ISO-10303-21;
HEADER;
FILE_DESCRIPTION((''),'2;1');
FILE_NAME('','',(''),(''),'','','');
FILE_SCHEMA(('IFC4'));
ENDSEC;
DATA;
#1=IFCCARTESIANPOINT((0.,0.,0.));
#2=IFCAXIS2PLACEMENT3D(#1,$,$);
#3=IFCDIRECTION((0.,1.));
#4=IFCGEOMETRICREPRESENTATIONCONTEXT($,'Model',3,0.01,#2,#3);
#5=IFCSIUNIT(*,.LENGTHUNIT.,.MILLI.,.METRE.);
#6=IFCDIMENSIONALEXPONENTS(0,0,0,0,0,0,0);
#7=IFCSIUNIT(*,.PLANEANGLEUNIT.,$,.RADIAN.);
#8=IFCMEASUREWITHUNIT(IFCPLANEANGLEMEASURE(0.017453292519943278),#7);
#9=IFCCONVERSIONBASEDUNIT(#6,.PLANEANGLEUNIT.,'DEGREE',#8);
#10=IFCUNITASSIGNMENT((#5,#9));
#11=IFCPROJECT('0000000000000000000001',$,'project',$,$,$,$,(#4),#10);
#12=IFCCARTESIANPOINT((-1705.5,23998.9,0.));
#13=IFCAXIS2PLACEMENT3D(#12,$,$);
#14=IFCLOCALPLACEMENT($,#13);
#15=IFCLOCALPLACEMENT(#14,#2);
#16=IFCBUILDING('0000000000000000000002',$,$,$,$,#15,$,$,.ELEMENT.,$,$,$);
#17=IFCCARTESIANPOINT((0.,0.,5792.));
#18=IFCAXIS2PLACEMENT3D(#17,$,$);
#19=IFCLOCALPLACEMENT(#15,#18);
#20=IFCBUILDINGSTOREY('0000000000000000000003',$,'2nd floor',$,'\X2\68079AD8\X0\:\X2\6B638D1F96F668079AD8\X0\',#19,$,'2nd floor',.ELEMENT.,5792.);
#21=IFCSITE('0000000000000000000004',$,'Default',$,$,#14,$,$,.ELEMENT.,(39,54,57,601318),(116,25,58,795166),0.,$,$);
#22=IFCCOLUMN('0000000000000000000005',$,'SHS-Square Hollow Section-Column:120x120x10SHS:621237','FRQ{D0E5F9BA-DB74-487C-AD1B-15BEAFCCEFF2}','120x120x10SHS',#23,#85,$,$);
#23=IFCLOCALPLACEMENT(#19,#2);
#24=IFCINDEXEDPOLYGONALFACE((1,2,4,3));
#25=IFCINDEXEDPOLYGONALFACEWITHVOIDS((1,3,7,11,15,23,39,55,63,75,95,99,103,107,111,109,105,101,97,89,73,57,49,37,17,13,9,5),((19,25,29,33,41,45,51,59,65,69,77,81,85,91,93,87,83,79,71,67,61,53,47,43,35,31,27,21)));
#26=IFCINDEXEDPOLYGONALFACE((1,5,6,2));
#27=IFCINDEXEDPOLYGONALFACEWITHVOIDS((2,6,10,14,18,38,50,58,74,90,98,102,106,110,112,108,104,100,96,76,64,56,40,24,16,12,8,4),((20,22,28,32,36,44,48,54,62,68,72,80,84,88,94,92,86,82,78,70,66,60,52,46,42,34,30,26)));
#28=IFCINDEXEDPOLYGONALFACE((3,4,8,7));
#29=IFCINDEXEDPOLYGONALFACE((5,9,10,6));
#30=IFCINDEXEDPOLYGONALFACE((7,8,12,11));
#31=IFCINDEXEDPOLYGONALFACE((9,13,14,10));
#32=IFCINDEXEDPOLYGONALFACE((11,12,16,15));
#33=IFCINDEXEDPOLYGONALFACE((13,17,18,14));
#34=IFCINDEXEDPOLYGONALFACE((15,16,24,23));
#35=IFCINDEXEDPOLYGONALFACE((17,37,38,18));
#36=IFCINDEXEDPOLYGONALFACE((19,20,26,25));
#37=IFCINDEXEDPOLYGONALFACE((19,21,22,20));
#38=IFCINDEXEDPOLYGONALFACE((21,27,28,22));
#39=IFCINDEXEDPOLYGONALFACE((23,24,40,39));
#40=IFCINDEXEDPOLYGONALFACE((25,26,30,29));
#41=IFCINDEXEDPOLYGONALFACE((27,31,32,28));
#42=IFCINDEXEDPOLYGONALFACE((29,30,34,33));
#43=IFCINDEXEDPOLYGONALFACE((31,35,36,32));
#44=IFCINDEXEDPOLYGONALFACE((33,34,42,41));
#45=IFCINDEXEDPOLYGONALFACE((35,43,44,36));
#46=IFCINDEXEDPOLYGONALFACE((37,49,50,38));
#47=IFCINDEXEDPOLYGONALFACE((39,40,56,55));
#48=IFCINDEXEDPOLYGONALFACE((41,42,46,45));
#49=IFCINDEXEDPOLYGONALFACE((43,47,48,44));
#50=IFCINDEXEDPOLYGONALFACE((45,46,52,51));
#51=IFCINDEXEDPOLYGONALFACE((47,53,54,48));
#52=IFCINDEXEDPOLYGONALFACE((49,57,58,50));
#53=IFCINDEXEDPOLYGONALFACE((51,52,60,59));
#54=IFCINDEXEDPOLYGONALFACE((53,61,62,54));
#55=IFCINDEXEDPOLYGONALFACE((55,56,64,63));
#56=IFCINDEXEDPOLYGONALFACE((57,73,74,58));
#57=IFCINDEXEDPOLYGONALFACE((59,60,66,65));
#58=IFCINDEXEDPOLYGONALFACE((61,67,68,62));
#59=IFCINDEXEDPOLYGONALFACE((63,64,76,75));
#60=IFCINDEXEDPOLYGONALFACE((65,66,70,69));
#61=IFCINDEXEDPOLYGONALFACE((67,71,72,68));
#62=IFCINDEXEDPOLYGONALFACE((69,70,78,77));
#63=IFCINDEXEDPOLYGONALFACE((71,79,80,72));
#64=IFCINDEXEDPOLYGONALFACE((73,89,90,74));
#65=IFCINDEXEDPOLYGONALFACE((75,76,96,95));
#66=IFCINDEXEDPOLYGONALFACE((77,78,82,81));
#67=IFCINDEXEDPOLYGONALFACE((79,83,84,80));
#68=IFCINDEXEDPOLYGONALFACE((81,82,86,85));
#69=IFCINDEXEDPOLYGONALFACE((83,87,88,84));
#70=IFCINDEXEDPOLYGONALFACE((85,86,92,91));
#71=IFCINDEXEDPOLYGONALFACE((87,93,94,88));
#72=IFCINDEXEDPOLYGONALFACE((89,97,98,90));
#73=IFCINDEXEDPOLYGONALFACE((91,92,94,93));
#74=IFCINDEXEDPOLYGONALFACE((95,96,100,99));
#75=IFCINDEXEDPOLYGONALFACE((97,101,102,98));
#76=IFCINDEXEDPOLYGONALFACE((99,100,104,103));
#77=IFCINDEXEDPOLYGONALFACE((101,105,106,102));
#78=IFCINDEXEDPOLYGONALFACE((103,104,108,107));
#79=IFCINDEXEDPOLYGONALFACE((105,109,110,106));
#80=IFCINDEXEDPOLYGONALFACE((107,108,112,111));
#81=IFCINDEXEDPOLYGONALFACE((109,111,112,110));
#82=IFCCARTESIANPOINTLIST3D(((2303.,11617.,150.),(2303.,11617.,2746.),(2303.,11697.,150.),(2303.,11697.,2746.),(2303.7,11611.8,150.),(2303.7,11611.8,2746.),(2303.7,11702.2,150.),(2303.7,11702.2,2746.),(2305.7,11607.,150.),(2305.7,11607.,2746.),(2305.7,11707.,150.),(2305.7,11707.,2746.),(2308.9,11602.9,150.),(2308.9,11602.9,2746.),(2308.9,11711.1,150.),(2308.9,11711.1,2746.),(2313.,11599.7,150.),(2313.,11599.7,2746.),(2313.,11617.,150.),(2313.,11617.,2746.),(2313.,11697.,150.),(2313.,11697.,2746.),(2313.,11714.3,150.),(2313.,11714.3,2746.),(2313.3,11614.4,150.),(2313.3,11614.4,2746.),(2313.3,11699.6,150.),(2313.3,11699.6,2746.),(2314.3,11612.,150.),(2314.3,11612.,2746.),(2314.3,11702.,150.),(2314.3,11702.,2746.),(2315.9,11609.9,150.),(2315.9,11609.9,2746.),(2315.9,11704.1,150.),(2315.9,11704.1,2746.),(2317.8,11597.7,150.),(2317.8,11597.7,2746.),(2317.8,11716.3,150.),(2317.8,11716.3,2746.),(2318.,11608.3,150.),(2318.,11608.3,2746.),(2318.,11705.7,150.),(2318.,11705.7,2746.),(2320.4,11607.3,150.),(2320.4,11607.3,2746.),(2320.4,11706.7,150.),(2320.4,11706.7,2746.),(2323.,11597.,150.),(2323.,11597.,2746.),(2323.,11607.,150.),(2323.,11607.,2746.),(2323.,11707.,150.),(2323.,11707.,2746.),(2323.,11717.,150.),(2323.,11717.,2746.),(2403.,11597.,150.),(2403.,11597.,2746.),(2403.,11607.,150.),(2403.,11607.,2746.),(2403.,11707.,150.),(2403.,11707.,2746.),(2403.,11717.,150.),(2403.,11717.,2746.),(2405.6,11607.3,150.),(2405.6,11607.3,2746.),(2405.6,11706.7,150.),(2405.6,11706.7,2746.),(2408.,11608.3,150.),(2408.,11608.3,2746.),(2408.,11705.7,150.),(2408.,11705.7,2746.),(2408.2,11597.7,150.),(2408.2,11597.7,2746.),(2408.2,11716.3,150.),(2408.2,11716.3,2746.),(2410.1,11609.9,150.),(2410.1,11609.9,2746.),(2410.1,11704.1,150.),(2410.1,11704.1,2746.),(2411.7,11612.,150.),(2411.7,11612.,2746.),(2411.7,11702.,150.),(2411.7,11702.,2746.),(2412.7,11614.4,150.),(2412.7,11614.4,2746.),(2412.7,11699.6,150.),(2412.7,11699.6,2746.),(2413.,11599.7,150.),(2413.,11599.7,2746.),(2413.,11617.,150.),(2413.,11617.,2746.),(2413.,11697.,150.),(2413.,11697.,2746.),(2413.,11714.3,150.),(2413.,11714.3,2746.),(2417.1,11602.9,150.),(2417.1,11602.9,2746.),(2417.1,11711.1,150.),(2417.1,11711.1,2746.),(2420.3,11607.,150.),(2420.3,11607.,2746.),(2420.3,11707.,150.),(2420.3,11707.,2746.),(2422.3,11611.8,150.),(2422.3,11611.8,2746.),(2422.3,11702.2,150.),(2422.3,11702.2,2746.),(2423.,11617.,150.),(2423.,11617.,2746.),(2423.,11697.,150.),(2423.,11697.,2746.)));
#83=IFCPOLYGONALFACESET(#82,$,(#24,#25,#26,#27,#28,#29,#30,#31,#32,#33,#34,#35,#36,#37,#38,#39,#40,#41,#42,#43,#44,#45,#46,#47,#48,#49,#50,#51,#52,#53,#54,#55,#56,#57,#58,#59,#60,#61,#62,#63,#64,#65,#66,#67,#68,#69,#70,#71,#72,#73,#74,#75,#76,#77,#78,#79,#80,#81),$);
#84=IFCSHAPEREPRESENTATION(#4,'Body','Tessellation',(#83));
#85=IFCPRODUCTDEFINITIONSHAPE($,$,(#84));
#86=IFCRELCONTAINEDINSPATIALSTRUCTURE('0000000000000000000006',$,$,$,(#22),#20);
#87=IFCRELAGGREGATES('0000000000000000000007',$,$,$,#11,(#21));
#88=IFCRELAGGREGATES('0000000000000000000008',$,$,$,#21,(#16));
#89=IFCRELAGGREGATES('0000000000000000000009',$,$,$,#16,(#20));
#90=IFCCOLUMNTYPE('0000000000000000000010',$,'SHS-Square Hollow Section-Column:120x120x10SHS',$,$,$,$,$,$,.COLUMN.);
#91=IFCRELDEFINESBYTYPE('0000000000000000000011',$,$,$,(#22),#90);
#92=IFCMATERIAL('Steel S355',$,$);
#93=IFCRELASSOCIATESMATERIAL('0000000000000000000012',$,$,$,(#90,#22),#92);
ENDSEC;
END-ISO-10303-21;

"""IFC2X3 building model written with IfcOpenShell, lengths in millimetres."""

from ifc_helpers import new_model, entity, si_unit, converted_unit, direction, frame, origin, origin_2d, place, context, project, spatial, hollow_rectangle, extrude, clip, halfspace, material, type_object, element, save


model = new_model("IFC2X3")

# Units and contexts
model_context = context("Model", 3, precision=0.01, world=origin(), true_north=direction((0.0, 1.0)))
ifc_project = project(units=[si_unit("LENGTHUNIT", "METRE", prefix="MILLI"), converted_unit("PLANEANGLEUNIT", "DEGREE", entity("IfcPlaneAngleMeasure", 0.017453292519943278), si_unit("PLANEANGLEUNIT", "RADIAN"), dimensions=[0, 0, 0, 0, 0, 0, 0])], contexts=[model_context])

# Site, building, storey
site_placement = place(None, frame((-1705.5, 23998.9, 0.0)))
site = spatial("IfcSite", under=ifc_project, at=site_placement, Name="Default", CompositionType="ELEMENT", RefLatitude=(39, 54, 57, 601318), RefLongitude=(116, 25, 58, 795166), RefElevation=0.0)
building_placement = place(site_placement, origin())
building = spatial("IfcBuilding", under=site, at=building_placement, CompositionType="ELEMENT")
storey_placement = place(building_placement, frame((0.0, 0.0, 5792.0)))
storey = spatial("IfcBuildingStorey", under=building, at=storey_placement, Name="2nd floor", ObjectType="标高:正负零标高", LongName="2nd floor", CompositionType="ELEMENT", Elevation=5792.0)

# Column
ifc_material_1 = material(Name="Steel S355")
column_type_1 = type_object("IfcColumnType", Name="SHS-Square Hollow Section-Column:120x120x10SHS", PredefinedType="COLUMN", material=ifc_material_1)
column_1_placement = place(storey_placement, frame((2363.0, 11657.0, 2830.9), z_axis=(0.0, 0.0, 1.0), x_axis=(0.0, -1.0, 0.0)))
element("IfcColumn", 1, at=column_1_placement, inside=storey, type_object=column_type_1, material=ifc_material_1, Name="SHS-Square Hollow Section-Column:120x120x10SHS:621237", Description="FRQ{D0E5F9BA-DB74-487C-AD1B-15BEAFCCEFF2}", ObjectType="120x120x10SHS", context=model_context, shape_type="Clipping", body=[
    clip(clip(extrude(hollow_rectangle(XDim=120.0, YDim=120.0, WallThickness=10.0, InnerFilletRadius=10.0, OuterFilletRadius=20.0, at=origin_2d()), origin(), (0.0, 0.0, -1.0), 2765.7), halfspace(frame((11657.0, -2363.0, -84.9), z_axis=(0.0, 0.0, -1.0), x_axis=(0.0, -1.0, 0.0)), True)), halfspace(frame((11657.0, -2363.0, -2680.9), z_axis=(0.0, 0.0, 1.0), x_axis=(0.0, 1.0, 0.0)), True)),
])

save(model, "model.ifc")
